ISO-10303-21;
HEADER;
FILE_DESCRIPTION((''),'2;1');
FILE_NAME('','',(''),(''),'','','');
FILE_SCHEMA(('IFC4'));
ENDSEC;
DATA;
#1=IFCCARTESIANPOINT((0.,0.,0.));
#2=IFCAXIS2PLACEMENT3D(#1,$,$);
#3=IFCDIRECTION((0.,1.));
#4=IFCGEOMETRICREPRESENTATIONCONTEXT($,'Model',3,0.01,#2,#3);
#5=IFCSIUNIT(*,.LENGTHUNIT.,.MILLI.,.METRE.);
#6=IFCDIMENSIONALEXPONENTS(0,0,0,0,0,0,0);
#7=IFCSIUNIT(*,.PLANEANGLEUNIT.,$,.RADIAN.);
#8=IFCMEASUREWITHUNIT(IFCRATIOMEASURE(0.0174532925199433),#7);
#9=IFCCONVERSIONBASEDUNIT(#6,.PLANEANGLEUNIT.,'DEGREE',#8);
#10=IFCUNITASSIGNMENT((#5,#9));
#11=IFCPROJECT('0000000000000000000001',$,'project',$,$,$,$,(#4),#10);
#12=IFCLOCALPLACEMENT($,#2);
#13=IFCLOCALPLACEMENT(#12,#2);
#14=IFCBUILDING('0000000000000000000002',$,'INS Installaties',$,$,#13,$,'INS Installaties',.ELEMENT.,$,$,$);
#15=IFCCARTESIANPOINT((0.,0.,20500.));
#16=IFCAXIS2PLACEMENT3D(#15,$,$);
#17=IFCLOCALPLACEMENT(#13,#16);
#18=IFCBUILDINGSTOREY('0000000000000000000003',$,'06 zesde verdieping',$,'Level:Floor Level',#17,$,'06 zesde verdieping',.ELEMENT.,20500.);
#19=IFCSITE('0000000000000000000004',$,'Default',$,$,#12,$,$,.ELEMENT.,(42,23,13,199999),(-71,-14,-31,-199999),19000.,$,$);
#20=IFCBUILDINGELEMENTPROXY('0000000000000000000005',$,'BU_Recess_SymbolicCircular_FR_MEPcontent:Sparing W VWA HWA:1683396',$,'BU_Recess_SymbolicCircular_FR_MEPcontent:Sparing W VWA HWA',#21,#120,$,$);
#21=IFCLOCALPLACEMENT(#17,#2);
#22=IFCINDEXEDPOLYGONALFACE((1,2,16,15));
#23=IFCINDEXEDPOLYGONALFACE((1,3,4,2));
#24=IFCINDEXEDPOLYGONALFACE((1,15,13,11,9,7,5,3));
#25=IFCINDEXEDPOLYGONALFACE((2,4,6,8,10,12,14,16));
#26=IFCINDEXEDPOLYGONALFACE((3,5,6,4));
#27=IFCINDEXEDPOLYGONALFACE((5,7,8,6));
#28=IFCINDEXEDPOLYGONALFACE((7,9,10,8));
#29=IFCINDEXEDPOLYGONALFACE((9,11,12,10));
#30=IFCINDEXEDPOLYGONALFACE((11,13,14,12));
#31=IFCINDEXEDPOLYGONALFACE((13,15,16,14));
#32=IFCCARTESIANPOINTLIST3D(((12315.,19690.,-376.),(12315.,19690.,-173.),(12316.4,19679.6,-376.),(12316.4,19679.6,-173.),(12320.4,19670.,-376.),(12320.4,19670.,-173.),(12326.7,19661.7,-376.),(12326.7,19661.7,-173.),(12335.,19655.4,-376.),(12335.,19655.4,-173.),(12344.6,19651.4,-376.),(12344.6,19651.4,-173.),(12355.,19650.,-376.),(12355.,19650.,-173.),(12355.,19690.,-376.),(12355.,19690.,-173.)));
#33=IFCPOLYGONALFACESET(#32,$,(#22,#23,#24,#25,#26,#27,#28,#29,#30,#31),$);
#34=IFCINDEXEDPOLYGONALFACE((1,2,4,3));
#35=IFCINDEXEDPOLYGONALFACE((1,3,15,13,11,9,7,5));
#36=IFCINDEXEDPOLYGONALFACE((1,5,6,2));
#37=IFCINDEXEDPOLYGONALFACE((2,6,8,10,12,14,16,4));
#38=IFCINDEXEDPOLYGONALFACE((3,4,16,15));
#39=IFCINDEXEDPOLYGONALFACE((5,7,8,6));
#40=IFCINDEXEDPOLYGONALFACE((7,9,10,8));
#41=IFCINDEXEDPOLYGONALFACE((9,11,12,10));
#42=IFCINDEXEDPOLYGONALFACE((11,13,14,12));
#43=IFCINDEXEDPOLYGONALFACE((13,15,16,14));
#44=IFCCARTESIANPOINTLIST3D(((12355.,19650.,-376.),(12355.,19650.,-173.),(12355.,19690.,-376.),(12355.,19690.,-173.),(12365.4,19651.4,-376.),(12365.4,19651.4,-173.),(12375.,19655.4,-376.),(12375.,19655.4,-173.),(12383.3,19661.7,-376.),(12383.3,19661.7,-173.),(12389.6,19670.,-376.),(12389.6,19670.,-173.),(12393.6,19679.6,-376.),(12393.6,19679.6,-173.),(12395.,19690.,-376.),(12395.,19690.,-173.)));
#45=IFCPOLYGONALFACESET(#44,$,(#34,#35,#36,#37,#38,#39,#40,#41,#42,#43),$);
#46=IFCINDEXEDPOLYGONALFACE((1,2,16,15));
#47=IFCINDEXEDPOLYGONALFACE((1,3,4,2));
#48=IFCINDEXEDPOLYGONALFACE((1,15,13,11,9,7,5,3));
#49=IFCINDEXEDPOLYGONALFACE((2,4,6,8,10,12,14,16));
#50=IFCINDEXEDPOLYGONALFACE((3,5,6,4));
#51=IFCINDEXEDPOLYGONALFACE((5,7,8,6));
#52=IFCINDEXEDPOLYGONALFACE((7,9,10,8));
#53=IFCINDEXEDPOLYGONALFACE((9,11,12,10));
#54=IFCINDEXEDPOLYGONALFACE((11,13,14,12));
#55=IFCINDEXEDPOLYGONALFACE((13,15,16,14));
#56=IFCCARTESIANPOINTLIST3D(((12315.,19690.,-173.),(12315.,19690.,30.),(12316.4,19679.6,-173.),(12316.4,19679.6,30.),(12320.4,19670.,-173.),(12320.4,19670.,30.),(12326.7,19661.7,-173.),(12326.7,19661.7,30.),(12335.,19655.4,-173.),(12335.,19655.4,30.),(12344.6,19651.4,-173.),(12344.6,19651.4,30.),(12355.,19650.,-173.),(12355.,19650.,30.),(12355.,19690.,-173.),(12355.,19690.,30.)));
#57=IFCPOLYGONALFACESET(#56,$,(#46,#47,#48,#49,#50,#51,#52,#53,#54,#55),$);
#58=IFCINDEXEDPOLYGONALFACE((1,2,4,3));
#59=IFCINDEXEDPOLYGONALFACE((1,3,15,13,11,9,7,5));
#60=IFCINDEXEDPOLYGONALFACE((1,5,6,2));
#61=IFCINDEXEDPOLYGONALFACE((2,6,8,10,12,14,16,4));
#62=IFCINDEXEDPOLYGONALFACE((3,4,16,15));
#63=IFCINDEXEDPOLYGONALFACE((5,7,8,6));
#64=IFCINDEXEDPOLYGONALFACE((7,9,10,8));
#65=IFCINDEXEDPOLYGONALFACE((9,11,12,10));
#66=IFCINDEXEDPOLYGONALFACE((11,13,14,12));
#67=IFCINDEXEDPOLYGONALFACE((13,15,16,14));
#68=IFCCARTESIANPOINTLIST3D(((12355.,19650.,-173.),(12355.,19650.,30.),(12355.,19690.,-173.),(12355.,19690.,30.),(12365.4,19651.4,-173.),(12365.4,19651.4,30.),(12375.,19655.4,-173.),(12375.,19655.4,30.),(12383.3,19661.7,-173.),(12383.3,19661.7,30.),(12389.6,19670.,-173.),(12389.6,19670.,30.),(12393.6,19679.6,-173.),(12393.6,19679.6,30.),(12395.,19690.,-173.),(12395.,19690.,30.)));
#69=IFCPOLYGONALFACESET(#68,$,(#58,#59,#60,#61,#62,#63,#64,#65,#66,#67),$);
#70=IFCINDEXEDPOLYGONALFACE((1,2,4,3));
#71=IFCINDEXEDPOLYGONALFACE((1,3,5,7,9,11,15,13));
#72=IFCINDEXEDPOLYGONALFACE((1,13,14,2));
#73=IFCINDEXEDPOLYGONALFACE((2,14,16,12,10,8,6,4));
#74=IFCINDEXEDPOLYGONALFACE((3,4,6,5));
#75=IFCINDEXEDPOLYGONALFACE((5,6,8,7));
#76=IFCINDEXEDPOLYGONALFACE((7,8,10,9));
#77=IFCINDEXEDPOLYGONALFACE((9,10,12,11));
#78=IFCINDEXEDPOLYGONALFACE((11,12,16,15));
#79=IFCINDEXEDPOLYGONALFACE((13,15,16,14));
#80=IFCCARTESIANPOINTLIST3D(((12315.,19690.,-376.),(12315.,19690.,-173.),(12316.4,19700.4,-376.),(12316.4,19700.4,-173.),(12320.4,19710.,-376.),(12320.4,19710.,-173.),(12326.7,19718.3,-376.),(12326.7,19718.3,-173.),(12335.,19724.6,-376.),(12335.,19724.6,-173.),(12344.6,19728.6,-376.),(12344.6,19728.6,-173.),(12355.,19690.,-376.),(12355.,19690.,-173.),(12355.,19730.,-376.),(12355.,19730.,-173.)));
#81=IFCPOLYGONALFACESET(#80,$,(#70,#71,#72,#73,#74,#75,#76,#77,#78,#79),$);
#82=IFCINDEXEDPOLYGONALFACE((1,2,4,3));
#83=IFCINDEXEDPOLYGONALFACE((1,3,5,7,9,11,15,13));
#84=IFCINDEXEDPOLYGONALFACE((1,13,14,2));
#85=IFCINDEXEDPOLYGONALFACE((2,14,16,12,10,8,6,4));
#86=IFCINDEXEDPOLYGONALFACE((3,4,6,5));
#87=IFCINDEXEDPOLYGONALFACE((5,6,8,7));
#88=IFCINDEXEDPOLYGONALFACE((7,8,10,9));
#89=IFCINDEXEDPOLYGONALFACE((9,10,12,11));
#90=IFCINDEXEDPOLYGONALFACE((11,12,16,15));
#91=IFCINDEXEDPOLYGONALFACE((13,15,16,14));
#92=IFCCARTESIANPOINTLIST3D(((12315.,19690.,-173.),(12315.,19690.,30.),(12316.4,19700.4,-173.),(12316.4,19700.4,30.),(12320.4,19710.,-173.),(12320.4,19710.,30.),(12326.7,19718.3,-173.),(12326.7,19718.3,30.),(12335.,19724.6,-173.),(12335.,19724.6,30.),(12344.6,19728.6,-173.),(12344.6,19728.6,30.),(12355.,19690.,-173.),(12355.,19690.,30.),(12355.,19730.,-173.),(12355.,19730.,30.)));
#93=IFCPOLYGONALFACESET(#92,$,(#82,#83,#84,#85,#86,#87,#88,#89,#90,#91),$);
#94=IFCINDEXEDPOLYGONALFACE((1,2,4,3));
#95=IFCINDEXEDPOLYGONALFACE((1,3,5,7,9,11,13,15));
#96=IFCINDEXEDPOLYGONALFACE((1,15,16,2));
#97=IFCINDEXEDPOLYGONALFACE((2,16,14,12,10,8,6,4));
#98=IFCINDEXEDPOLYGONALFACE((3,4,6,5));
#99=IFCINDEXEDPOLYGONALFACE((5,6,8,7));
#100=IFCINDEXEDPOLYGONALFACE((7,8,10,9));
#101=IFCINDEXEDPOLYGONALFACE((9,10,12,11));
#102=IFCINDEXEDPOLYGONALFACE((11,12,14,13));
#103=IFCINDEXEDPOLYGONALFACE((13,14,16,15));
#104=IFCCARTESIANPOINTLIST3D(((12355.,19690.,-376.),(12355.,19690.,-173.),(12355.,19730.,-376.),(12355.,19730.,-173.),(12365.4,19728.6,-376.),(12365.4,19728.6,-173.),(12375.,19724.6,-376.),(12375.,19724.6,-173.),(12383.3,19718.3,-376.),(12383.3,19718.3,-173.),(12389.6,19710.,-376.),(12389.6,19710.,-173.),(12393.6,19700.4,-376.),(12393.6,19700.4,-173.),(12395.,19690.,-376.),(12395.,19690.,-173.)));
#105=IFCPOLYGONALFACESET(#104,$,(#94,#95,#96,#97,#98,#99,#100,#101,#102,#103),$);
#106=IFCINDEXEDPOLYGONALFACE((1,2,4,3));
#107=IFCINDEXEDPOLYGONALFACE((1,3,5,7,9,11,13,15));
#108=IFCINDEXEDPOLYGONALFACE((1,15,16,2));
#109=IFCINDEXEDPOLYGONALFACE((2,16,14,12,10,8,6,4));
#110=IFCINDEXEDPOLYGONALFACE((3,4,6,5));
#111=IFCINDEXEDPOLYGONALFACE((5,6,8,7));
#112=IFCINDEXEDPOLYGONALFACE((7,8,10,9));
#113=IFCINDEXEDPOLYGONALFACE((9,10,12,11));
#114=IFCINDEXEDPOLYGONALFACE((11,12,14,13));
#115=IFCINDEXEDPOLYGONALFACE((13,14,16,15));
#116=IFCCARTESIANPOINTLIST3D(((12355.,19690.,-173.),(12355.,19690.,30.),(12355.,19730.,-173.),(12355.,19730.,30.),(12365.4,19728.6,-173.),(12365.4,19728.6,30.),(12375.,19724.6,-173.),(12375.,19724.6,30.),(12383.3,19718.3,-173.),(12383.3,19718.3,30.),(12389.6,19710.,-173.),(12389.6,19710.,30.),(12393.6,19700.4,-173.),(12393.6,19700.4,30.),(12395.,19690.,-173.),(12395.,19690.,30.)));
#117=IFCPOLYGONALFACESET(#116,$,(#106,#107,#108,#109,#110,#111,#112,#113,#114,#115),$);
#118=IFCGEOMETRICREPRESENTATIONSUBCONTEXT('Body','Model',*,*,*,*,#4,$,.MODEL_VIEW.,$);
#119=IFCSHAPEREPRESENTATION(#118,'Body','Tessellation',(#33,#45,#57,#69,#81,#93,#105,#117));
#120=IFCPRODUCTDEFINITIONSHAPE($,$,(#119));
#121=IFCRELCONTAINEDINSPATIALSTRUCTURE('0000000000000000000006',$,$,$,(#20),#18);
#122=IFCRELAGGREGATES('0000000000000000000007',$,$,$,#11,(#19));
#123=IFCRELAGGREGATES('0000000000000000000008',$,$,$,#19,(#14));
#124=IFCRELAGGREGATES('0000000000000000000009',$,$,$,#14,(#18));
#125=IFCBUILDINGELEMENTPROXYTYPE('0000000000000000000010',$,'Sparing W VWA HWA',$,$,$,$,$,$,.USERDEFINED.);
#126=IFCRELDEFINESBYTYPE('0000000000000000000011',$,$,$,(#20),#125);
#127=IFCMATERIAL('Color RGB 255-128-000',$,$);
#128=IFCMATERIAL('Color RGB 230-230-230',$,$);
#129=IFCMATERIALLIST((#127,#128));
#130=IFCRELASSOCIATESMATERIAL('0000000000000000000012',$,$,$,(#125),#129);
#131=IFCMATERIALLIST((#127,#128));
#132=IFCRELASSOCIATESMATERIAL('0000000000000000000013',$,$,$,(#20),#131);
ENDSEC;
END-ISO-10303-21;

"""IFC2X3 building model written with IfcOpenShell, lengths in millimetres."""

from ifc_helpers import new_model, entity, si_unit, converted_unit, direction, frame, frame_2d, origin, place, context, subcontext, project, spatial, polyline, circle_curve, parameter, trimmed, segment, composite_curve, outline, extrude, source, transform, mapped, material, material_list, type_object, type_shapes, element, save


model = new_model("IFC2X3")

# Units and contexts
model_context = context("Model", 3, precision=0.01, world=origin(), true_north=direction((0.0, 1.0)))
body_context = subcontext(model_context, "Body", "Model", "MODEL_VIEW")
ifc_project = project(units=[si_unit("LENGTHUNIT", "METRE", prefix="MILLI"), converted_unit("PLANEANGLEUNIT", "DEGREE", entity("IfcRatioMeasure", 0.0174532925199433), si_unit("PLANEANGLEUNIT", "RADIAN"), dimensions=[0, 0, 0, 0, 0, 0, 0])], contexts=[model_context])

# Site, building, storey
site_placement = place(None, origin())
site = spatial("IfcSite", under=ifc_project, at=site_placement, Name="Default", CompositionType="ELEMENT", RefLatitude=(42, 23, 13, 199999), RefLongitude=(-71, -14, -31, -199999), RefElevation=19000.0)
building_placement = place(site_placement, origin())
building = spatial("IfcBuilding", under=site, at=building_placement, Name="INS Installaties", LongName="INS Installaties", CompositionType="ELEMENT")
storey_placement = place(building_placement, frame((0.0, 0.0, 20500.0)))
storey = spatial("IfcBuildingStorey", under=building, at=storey_placement, Name="06 zesde verdieping", ObjectType="Level:Floor Level", LongName="06 zesde verdieping", CompositionType="ELEMENT", Elevation=20500.0)

# Building element proxy
ifc_material_1 = material(Name="Color RGB 255-128-000")
ifc_material_2 = material(Name="Color RGB 230-230-230")
ifc_material_list_1 = material_list([ifc_material_1, ifc_material_2])
ifc_material_list_2 = material_list([ifc_material_1, ifc_material_2])
building_element_proxy_type_1 = type_object("IfcBuildingElementProxyType", Name="Sparing W VWA HWA", PredefinedType="USERDEFINED", material=ifc_material_list_2)
shared_shape_1 = source(origin(), body_context, "Body", "SweptSolid", [
    extrude(outline(composite_curve([segment(trimmed(circle_curve(frame_2d((13.3, 13.3), x_axis=(1.0, 0.0)), 40.0), [parameter(180.0)], [parameter(270.0)], True, "PARAMETER"), True, "CONTINUOUS"), segment(polyline([(13.3, -26.7), (13.3, 13.3)]), True, "CONTINUOUS"), segment(polyline([(13.3, 13.3), (-26.7, 13.3)]), True, "CONTINUOUS")], self_intersect=False)), frame((13.3, 13.3, -403.0), z_axis=(0.0, 0.0, 1.0), x_axis=(-1.0, 0.0, 0.0)), (0.0, 0.0, 1.0), 203.0),
    extrude(outline(composite_curve([segment(polyline([(-26.7, -13.3), (13.3, -13.3)]), True, "CONTINUOUS"), segment(polyline([(13.3, -13.3), (13.3, 26.7)]), True, "CONTINUOUS"), segment(trimmed(circle_curve(frame_2d((13.3, -13.3), x_axis=(1.0, 0.0)), 40.0), [parameter(90.0)], [parameter(180.0)], True, "PARAMETER"), True, "CONTINUOUS")], self_intersect=False)), frame((-13.3, 13.3, -403.0)), (0.0, 0.0, 1.0), 203.0),
    extrude(outline(composite_curve([segment(trimmed(circle_curve(frame_2d((13.3, 13.3), x_axis=(1.0, 0.0)), 40.0), [parameter(180.0)], [parameter(270.0)], True, "PARAMETER"), True, "CONTINUOUS"), segment(polyline([(13.3, -26.7), (13.3, 13.3)]), True, "CONTINUOUS"), segment(polyline([(13.3, 13.3), (-26.7, 13.3)]), True, "CONTINUOUS")], self_intersect=False)), frame((13.3, 13.3, -200.0), z_axis=(0.0, 0.0, 1.0), x_axis=(-1.0, 0.0, 0.0)), (0.0, 0.0, 1.0), 203.0),
    extrude(outline(composite_curve([segment(polyline([(-26.7, -13.3), (13.3, -13.3)]), True, "CONTINUOUS"), segment(polyline([(13.3, -13.3), (13.3, 26.7)]), True, "CONTINUOUS"), segment(trimmed(circle_curve(frame_2d((13.3, -13.3), x_axis=(1.0, 0.0)), 40.0), [parameter(90.0)], [parameter(180.0)], True, "PARAMETER"), True, "CONTINUOUS")], self_intersect=False)), frame((-13.3, 13.3, -200.0)), (0.0, 0.0, 1.0), 203.0),
    extrude(outline(composite_curve([segment(polyline([(-26.7, -13.3), (13.3, -13.3)]), True, "CONTINUOUS"), segment(polyline([(13.3, -13.3), (13.3, 26.7)]), True, "CONTINUOUS"), segment(trimmed(circle_curve(frame_2d((13.3, -13.3), x_axis=(1.0, 0.0)), 40.0), [parameter(90.0)], [parameter(180.0)], True, "PARAMETER"), True, "CONTINUOUS")], self_intersect=False)), frame((13.3, -13.3, -403.0), z_axis=(0.0, 0.0, 1.0), x_axis=(-1.0, 0.0, 0.0)), (0.0, 0.0, 1.0), 203.0),
    extrude(outline(composite_curve([segment(polyline([(-26.7, -13.3), (13.3, -13.3)]), True, "CONTINUOUS"), segment(polyline([(13.3, -13.3), (13.3, 26.7)]), True, "CONTINUOUS"), segment(trimmed(circle_curve(frame_2d((13.3, -13.3), x_axis=(1.0, 0.0)), 40.0), [parameter(90.0)], [parameter(180.0)], True, "PARAMETER"), True, "CONTINUOUS")], self_intersect=False)), frame((13.3, -13.3, -200.0), z_axis=(0.0, 0.0, 1.0), x_axis=(-1.0, 0.0, 0.0)), (0.0, 0.0, 1.0), 203.0),
    extrude(outline(composite_curve([segment(trimmed(circle_curve(frame_2d((13.3, 13.3), x_axis=(1.0, 0.0)), 40.0), [parameter(180.0)], [parameter(270.0)], True, "PARAMETER"), True, "CONTINUOUS"), segment(polyline([(13.3, -26.7), (13.3, 13.3)]), True, "CONTINUOUS"), segment(polyline([(13.3, 13.3), (-26.7, 13.3)]), True, "CONTINUOUS")], self_intersect=False)), frame((-13.3, -13.3, -403.0)), (0.0, 0.0, 1.0), 203.0),
    extrude(outline(composite_curve([segment(trimmed(circle_curve(frame_2d((13.3, 13.3), x_axis=(1.0, 0.0)), 40.0), [parameter(180.0)], [parameter(270.0)], True, "PARAMETER"), True, "CONTINUOUS"), segment(polyline([(13.3, -26.7), (13.3, 13.3)]), True, "CONTINUOUS"), segment(polyline([(13.3, 13.3), (-26.7, 13.3)]), True, "CONTINUOUS")], self_intersect=False)), frame((-13.3, -13.3, -200.0)), (0.0, 0.0, 1.0), 203.0),
])
type_shapes(building_element_proxy_type_1, [shared_shape_1])
proxy_1_placement = place(storey_placement, frame((12355.0, 19690.0, 27.0), z_axis=(0.0, 0.0, 1.0), x_axis=(-1.0, 0.0, 0.0)))
element("IfcBuildingElementProxy", 1, at=proxy_1_placement, inside=storey, type_object=building_element_proxy_type_1, material=ifc_material_list_1, Name="BU_Recess_SymbolicCircular_FR_MEPcontent:Sparing W VWA HWA:1683396", ObjectType="BU_Recess_SymbolicCircular_FR_MEPcontent:Sparing W VWA HWA", context=body_context, shape_type="MappedRepresentation", body=[
    mapped(shared_shape_1, transform((0.0, 0.0, 0.0), scale=1.0)),
])

save(model, "model.ifc")
